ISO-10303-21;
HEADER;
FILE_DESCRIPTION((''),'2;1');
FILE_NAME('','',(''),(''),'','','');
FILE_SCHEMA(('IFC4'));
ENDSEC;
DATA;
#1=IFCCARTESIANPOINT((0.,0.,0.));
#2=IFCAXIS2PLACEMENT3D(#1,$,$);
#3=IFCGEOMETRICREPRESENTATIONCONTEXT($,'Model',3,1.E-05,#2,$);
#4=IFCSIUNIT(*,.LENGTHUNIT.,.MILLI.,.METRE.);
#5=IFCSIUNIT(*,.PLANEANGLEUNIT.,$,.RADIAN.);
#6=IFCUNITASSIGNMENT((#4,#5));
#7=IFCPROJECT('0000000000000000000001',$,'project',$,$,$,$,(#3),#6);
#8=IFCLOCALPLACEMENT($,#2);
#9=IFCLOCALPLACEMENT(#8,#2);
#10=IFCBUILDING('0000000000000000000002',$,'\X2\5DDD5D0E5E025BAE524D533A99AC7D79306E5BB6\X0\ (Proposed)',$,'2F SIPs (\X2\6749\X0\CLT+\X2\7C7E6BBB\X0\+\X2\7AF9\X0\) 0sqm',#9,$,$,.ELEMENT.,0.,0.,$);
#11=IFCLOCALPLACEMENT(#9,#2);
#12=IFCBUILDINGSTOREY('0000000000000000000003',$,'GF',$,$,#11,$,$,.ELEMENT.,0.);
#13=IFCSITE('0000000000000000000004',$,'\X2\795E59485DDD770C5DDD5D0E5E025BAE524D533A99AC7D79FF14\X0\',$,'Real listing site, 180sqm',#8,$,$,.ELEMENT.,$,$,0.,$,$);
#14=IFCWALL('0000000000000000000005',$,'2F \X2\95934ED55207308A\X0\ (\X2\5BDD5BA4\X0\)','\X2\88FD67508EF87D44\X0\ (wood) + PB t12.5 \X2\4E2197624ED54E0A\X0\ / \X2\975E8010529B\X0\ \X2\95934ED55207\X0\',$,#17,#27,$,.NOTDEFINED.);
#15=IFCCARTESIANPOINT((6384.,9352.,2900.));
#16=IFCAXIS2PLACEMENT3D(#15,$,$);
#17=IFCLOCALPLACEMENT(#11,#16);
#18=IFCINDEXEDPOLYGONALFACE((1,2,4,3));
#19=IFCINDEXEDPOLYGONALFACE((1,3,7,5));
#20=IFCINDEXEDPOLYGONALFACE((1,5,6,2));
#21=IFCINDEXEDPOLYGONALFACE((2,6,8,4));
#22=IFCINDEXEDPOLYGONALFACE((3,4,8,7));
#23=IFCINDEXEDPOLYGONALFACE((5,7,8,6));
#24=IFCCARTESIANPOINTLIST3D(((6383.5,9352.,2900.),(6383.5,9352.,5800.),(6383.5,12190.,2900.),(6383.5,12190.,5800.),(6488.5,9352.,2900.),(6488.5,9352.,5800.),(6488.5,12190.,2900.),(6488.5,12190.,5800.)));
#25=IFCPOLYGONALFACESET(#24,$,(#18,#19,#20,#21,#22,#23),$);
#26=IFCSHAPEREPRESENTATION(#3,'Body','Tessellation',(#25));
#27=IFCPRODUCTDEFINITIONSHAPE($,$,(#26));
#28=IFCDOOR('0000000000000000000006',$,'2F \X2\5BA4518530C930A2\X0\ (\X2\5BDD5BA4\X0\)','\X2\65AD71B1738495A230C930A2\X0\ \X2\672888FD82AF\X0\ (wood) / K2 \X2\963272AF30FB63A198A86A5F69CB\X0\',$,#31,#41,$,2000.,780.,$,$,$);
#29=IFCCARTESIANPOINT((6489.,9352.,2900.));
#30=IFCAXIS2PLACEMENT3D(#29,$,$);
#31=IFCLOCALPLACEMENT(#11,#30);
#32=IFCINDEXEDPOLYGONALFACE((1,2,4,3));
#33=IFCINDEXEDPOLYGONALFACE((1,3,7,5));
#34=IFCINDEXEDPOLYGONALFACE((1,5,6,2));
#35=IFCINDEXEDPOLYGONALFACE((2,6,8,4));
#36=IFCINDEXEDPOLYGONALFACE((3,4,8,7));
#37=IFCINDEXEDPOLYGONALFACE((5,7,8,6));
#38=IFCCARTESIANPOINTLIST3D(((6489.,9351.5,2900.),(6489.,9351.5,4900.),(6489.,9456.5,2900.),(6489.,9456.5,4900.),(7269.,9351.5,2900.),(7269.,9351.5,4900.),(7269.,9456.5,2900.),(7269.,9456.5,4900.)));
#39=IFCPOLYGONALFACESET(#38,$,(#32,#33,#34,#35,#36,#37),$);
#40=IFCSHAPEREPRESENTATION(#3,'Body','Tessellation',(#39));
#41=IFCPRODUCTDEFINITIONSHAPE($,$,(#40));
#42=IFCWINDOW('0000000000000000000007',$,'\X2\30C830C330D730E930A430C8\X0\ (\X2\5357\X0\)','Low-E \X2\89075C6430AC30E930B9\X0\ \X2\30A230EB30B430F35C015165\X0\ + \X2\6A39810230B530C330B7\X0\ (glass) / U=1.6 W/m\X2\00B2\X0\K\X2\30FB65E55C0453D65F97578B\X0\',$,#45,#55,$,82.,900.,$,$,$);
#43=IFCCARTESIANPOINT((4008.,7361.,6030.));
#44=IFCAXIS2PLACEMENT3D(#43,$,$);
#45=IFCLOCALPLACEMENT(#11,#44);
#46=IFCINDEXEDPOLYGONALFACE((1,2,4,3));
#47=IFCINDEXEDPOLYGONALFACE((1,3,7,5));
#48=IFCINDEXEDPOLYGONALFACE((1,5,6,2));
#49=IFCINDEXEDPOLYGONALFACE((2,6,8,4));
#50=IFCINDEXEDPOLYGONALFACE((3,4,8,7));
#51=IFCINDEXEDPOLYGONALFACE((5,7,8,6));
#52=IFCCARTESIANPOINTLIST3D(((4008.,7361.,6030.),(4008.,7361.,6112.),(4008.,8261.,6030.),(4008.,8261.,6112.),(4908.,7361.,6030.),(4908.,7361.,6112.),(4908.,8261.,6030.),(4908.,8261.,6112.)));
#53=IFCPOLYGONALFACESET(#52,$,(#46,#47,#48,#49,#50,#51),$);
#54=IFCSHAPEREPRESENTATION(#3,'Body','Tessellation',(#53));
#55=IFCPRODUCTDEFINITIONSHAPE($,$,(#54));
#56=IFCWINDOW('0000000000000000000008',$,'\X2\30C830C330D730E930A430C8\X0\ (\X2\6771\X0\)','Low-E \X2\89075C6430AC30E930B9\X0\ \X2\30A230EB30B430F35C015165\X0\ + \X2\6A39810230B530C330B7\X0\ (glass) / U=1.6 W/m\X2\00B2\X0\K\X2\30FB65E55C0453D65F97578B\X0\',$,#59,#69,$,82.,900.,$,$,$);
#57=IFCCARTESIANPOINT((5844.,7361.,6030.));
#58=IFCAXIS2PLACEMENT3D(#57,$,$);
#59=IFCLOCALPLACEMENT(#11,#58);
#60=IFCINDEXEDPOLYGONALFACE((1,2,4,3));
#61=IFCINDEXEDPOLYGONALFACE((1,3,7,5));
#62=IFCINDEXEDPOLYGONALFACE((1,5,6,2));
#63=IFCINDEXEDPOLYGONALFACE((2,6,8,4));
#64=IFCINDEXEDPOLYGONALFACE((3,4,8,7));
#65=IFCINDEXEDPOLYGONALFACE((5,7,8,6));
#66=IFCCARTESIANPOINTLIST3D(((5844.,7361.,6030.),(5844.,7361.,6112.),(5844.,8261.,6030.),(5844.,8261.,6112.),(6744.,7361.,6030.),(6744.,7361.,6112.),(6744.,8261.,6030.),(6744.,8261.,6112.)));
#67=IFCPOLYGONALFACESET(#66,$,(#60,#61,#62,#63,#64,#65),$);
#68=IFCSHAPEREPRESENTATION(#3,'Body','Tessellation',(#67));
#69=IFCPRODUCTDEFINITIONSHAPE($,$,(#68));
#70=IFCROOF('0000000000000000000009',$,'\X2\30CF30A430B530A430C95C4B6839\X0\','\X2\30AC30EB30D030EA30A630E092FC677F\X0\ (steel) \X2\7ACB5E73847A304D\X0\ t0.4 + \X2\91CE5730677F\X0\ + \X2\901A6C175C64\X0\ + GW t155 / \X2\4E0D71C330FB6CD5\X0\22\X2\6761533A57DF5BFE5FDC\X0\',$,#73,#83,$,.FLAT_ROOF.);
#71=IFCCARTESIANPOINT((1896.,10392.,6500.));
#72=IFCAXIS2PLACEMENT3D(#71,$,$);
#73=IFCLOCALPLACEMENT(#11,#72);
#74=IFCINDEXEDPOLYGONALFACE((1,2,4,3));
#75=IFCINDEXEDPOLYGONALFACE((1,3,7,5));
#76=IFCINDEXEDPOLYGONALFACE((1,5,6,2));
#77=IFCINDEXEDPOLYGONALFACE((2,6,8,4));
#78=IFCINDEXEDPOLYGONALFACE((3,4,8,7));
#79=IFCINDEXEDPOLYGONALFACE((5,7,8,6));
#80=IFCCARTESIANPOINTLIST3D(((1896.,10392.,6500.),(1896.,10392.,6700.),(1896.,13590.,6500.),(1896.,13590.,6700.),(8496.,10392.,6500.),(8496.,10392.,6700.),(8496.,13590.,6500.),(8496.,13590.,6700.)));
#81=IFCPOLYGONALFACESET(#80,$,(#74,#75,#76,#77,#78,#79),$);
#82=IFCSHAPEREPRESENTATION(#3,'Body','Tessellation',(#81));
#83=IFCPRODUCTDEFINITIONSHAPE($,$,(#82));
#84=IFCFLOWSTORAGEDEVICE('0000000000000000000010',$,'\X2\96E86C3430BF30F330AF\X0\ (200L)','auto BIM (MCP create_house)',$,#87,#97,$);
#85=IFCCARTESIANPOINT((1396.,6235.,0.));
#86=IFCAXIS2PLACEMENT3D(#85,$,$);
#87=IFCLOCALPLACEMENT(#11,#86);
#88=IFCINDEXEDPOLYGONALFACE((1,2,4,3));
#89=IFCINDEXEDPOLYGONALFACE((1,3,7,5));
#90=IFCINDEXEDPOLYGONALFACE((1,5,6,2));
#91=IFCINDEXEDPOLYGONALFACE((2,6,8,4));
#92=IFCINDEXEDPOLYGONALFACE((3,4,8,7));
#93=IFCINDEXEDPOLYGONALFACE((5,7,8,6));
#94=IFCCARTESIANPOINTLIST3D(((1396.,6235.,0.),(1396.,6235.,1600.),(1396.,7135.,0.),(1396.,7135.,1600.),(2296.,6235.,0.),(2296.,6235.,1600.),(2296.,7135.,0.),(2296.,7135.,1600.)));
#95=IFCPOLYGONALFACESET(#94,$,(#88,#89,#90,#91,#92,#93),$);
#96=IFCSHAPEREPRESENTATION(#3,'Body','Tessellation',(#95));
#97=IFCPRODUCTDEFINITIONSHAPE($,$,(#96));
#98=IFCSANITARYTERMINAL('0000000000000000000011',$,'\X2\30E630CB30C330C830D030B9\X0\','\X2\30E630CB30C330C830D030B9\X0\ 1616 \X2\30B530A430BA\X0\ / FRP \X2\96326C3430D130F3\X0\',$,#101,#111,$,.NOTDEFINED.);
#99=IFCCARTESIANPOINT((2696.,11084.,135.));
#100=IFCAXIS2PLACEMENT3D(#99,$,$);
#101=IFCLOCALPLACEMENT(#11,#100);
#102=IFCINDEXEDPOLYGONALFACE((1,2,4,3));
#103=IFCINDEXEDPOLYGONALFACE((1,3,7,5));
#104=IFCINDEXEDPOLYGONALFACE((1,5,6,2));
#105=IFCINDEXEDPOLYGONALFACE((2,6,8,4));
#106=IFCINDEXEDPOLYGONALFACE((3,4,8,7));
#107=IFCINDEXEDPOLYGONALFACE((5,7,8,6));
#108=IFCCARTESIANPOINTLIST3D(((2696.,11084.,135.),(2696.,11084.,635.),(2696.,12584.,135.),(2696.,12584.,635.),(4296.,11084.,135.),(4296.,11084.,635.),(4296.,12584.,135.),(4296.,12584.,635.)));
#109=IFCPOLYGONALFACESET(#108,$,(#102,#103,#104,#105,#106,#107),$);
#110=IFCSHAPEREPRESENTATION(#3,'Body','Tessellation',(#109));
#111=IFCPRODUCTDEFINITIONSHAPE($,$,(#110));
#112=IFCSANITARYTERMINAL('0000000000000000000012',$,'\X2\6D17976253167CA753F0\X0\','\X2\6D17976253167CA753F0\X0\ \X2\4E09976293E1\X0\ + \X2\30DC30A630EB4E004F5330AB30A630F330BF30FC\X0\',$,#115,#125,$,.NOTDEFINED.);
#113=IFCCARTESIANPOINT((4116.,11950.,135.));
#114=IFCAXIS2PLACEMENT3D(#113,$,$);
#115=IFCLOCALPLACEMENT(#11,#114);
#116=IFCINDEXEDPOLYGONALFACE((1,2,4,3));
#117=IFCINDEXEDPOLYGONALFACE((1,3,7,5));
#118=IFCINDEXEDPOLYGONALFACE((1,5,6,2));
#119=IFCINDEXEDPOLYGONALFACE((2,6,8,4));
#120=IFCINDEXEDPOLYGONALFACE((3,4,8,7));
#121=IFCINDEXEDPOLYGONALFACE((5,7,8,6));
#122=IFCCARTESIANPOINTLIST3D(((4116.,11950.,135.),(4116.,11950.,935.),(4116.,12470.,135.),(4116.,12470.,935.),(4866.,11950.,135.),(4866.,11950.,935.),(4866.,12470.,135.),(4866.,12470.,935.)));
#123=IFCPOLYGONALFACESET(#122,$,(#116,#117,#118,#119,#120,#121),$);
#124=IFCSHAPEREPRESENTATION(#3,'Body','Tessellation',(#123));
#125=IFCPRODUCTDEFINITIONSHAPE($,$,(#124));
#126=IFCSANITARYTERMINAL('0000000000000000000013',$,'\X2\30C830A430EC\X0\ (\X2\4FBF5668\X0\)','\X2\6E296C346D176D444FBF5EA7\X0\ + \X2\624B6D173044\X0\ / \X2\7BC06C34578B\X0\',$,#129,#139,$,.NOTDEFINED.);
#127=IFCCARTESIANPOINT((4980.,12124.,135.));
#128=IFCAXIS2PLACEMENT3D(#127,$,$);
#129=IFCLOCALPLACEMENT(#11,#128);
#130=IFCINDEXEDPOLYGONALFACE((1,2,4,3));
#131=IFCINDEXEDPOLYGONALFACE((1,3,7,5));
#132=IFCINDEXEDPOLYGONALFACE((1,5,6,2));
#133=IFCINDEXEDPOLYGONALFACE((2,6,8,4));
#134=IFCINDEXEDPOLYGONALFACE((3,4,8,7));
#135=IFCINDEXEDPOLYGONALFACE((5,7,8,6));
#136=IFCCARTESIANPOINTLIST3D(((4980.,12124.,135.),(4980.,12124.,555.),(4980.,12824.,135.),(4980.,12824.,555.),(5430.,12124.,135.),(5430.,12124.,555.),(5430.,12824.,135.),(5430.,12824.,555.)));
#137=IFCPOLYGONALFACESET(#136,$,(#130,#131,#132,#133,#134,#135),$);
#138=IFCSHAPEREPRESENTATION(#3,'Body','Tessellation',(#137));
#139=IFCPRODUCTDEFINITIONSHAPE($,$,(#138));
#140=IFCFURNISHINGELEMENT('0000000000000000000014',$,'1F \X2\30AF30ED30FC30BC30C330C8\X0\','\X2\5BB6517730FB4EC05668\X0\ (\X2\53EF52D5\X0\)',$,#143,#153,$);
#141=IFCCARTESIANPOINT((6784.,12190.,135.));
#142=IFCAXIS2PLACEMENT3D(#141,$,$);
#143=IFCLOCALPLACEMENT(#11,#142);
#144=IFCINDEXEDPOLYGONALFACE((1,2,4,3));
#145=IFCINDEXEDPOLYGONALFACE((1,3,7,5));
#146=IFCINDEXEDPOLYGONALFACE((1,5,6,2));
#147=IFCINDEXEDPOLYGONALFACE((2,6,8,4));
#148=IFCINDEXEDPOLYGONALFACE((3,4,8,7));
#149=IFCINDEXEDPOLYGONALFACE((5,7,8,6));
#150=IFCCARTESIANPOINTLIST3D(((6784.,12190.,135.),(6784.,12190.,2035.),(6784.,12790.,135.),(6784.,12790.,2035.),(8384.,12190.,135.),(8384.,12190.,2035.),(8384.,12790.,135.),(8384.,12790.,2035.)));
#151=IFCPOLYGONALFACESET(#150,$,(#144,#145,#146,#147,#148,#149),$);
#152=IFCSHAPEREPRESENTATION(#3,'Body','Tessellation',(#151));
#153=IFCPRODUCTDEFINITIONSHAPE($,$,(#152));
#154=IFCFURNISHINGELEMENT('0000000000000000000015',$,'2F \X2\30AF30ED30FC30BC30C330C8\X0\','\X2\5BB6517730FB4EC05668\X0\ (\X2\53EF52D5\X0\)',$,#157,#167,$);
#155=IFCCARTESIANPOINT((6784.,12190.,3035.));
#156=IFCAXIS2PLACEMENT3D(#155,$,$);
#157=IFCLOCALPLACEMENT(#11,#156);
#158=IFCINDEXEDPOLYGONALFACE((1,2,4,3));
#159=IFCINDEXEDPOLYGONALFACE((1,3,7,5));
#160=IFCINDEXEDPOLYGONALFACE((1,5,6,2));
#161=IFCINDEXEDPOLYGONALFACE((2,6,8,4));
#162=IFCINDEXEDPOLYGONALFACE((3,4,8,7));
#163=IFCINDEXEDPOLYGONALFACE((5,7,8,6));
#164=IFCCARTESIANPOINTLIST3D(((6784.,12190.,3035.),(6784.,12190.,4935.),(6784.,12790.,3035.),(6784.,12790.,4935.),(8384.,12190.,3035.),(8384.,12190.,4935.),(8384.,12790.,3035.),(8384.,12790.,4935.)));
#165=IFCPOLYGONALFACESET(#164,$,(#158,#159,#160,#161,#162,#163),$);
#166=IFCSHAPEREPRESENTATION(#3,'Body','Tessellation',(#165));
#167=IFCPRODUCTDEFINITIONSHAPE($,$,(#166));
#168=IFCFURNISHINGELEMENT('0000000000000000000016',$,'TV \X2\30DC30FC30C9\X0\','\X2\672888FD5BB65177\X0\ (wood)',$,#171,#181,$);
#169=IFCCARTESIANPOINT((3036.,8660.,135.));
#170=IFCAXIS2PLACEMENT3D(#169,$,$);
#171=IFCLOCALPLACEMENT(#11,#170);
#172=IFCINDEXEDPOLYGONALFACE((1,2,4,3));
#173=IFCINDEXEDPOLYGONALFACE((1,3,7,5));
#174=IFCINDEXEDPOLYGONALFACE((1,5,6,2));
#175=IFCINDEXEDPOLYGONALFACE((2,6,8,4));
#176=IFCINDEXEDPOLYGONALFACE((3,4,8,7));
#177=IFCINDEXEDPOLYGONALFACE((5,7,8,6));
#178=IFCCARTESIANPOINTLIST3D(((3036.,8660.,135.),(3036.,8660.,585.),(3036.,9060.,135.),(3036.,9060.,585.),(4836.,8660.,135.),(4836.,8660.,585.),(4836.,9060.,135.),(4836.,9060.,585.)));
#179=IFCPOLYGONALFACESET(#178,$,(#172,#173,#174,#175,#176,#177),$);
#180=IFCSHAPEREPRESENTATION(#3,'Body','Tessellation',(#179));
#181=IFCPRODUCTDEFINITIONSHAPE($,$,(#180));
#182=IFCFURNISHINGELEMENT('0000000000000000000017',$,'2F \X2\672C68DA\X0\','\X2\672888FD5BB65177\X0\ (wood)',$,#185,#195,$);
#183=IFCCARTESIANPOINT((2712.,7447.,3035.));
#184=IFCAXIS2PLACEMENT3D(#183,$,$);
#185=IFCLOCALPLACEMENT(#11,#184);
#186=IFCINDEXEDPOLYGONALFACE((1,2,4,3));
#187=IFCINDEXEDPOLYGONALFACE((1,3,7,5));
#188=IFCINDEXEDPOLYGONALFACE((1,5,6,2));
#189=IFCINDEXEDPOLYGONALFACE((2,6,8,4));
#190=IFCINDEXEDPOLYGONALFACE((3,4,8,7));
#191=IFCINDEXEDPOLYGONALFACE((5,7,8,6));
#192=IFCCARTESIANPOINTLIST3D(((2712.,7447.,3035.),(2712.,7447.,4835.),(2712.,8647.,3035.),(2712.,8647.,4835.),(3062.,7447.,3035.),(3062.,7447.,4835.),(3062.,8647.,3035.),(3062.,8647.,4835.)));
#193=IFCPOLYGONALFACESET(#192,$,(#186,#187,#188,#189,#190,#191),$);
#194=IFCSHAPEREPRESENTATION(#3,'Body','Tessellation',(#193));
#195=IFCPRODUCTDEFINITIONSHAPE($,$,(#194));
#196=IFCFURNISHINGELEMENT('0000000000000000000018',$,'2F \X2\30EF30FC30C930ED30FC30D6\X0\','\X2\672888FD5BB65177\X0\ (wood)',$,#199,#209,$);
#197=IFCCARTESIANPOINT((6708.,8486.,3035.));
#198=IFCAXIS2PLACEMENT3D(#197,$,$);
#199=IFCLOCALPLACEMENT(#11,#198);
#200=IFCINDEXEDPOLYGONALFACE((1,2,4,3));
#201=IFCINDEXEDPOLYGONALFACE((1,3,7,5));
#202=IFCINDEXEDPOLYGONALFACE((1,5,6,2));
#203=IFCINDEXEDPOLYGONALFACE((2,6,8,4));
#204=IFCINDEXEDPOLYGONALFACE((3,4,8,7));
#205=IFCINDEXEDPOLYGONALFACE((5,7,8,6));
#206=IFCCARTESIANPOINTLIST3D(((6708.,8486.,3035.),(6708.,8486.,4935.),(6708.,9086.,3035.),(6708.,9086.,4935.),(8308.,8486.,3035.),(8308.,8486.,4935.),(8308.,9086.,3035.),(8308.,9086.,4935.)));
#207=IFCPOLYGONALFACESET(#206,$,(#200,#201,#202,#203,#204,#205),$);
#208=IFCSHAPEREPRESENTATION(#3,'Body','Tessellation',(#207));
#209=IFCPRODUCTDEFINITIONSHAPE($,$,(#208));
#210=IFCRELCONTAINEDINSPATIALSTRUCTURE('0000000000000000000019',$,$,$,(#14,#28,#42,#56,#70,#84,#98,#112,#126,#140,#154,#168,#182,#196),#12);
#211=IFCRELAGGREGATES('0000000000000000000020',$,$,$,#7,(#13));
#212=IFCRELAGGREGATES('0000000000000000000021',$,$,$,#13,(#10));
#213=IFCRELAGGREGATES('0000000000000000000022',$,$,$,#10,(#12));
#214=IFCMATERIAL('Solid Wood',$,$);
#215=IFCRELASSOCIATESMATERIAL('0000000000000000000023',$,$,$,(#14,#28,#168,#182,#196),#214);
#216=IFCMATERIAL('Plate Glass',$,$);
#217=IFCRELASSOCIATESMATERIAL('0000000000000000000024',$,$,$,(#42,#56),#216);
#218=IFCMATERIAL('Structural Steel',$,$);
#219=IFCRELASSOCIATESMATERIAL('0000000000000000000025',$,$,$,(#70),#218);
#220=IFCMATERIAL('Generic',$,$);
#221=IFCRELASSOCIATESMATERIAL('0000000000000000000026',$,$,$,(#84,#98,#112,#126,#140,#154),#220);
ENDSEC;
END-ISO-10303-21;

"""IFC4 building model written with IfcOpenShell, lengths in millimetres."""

from ifc_helpers import new_model, si_unit, frame, frame_2d, origin, place, context, project, spatial, rectangle, extrude, material, element, save


model = new_model("IFC4")

# Units and contexts
model_context = context("Model", 3, precision=1e-05, world=origin())
ifc_project = project(units=[si_unit("LENGTHUNIT", "METRE", prefix="MILLI"), si_unit("PLANEANGLEUNIT", "RADIAN")], contexts=[model_context])

# Site, building, storey
site_placement = place(None, origin())
site = spatial("IfcSite", under=ifc_project, at=site_placement, Name="神奈川県川崎市宮前区馬絹４", ObjectType="Real listing site, 180sqm", CompositionType="ELEMENT", RefElevation=0.0)
building_placement = place(site_placement, origin())
building = spatial("IfcBuilding", under=site, at=building_placement, Name="川崎市宮前区馬絹の家 (Proposed)", ObjectType="2F SIPs (杉CLT+籾殻+竹) 0sqm", CompositionType="ELEMENT", ElevationOfRefHeight=0.0, ElevationOfTerrain=0.0)
storey_placement = place(building_placement, origin())
storey = spatial("IfcBuildingStorey", under=building, at=storey_placement, Name="GF", CompositionType="ELEMENT", Elevation=0.0)

# Shared definitions
ifc_material_1 = material(Name="Solid Wood")
ifc_material_2 = material(Name="Plate Glass")

# Wall
wall_1_placement = place(storey_placement, frame((6384.0, 9352.0, 2900.0)))
element("IfcWall", 1, at=wall_1_placement, inside=storey, material=ifc_material_1, Name="2F 間仕切り (寝室)", Description="製材軸組 (wood) + PB t12.5 両面仕上 / 非耐力 間仕切", PredefinedType="NOTDEFINED", context=model_context, shape_type="SweptSolid", body=[
    extrude(rectangle(XDim=105.0, YDim=2838.0, at=frame_2d((52.0, 1419.0))), frame((6384.0, 9352.0, 2900.0)), (0.0, 0.0, 1.0), 2900.0),
])

# Door
door_1_placement = place(storey_placement, frame((6489.0, 9352.0, 2900.0)))
element("IfcDoor", 2, at=door_1_placement, inside=storey, material=ifc_material_1, Name="2F 室内ドア (寝室)", Description="断熱玄関ドア 木製芯 (wood) / K2 防犯・採風機構", OverallHeight=2000.0, OverallWidth=780.0, context=model_context, shape_type="SweptSolid", body=[
    extrude(rectangle(XDim=780.0, YDim=105.0, at=frame_2d((390.0, 52.0))), frame((6489.0, 9352.0, 2900.0)), (0.0, 0.0, 1.0), 2000.0),
])

# Windows
window_1_placement = place(storey_placement, frame((4008.0, 7361.0, 6030.0)))
element("IfcWindow", 3, at=window_1_placement, inside=storey, material=ifc_material_2, Name="トップライト (南)", Description="Low-E 複層ガラス アルゴン封入 + 樹脂サッシ (glass) / U=1.6 W/m²K・日射取得型", OverallHeight=82.0, OverallWidth=900.0, context=model_context, shape_type="SweptSolid", body=[
    extrude(rectangle(XDim=900.0, YDim=900.0, at=frame_2d((450.0, 450.0))), frame((4008.0, 7361.0, 6030.0)), (0.0, 0.0, 1.0), 82.0),
])
window_2_placement = place(storey_placement, frame((5844.0, 7361.0, 6030.0)))
element("IfcWindow", 4, at=window_2_placement, inside=storey, material=ifc_material_2, Name="トップライト (東)", Description="Low-E 複層ガラス アルゴン封入 + 樹脂サッシ (glass) / U=1.6 W/m²K・日射取得型", OverallHeight=82.0, OverallWidth=900.0, context=model_context, shape_type="SweptSolid", body=[
    extrude(rectangle(XDim=900.0, YDim=900.0, at=frame_2d((450.0, 450.0))), frame((5844.0, 7361.0, 6030.0)), (0.0, 0.0, 1.0), 82.0),
])

# Roof
ifc_material_3 = material(Name="Structural Steel")
roof_placement = place(storey_placement, frame((1896.0, 10392.0, 6500.0)))
element("IfcRoof", 5, at=roof_placement, inside=storey, material=ifc_material_3, Name="ハイサイド屋根", Description="ガルバリウム鋼板 (steel) 立平葺き t0.4 + 野地板 + 通気層 + GW t155 / 不燃・法22条区域対応", PredefinedType="FLAT_ROOF", context=model_context, shape_type="SweptSolid", body=[
    extrude(rectangle(XDim=6600.0, YDim=3198.0, at=frame_2d((3300.0, 1599.0))), frame((1896.0, 10392.0, 6500.0)), (0.0, 0.0, 1.0), 200.0),
])

# Flow storage device
ifc_material_4 = material(Name="Generic")
flow_storage_device_placement = place(storey_placement, frame((1396.0, 6235.0, 0.0)))
element("IfcFlowStorageDevice", 6, at=flow_storage_device_placement, inside=storey, material=ifc_material_4, Name="雨水タンク (200L)", Description="auto BIM (MCP create_house)", context=model_context, shape_type="SweptSolid", body=[
    extrude(rectangle(XDim=900.0, YDim=900.0, at=frame_2d((450.0, 450.0))), frame((1396.0, 6235.0, 0.0)), (0.0, 0.0, 1.0), 1600.0),
])

# Sanitary terminals
sanitary_terminal_1_placement = place(storey_placement, frame((2696.0, 11084.0, 135.0)))
element("IfcSanitaryTerminal", 7, at=sanitary_terminal_1_placement, inside=storey, material=ifc_material_4, Name="ユニットバス", Description="ユニットバス 1616 サイズ / FRP 防水パン", PredefinedType="NOTDEFINED", context=model_context, shape_type="SweptSolid", body=[
    extrude(rectangle(XDim=1600.0, YDim=1500.0, at=frame_2d((800.0, 750.0))), frame((2696.0, 11084.0, 135.0)), (0.0, 0.0, 1.0), 500.0),
])
sanitary_terminal_2_placement = place(storey_placement, frame((4116.0, 11950.0, 135.0)))
element("IfcSanitaryTerminal", 8, at=sanitary_terminal_2_placement, inside=storey, material=ifc_material_4, Name="洗面化粧台", Description="洗面化粧台 三面鏡 + ボウル一体カウンター", PredefinedType="NOTDEFINED", context=model_context, shape_type="SweptSolid", body=[
    extrude(rectangle(XDim=750.0, YDim=520.0, at=frame_2d((375.0, 260.0))), frame((4116.0, 11950.0, 135.0)), (0.0, 0.0, 1.0), 800.0),
])
sanitary_terminal_3_placement = place(storey_placement, frame((4980.0, 12124.0, 135.0)))
element("IfcSanitaryTerminal", 9, at=sanitary_terminal_3_placement, inside=storey, material=ifc_material_4, Name="トイレ (便器)", Description="温水洗浄便座 + 手洗い / 節水型", PredefinedType="NOTDEFINED", context=model_context, shape_type="SweptSolid", body=[
    extrude(rectangle(XDim=450.0, YDim=700.0, at=frame_2d((225.0, 350.0))), frame((4980.0, 12124.0, 135.0)), (0.0, 0.0, 1.0), 420.0),
])

# Furnishing elements
furnishing_1_placement = place(storey_placement, frame((6784.0, 12190.0, 135.0)))
element("IfcFurnishingElement", 10, at=furnishing_1_placement, inside=storey, material=ifc_material_4, Name="1F クローゼット", Description="家具・什器 (可動)", context=model_context, shape_type="SweptSolid", body=[
    extrude(rectangle(XDim=1600.0, YDim=600.0, at=frame_2d((800.0, 300.0))), frame((6784.0, 12190.0, 135.0)), (0.0, 0.0, 1.0), 1900.0),
])
furnishing_2_placement = place(storey_placement, frame((6784.0, 12190.0, 3035.0)))
element("IfcFurnishingElement", 11, at=furnishing_2_placement, inside=storey, material=ifc_material_4, Name="2F クローゼット", Description="家具・什器 (可動)", context=model_context, shape_type="SweptSolid", body=[
    extrude(rectangle(XDim=1600.0, YDim=600.0, at=frame_2d((800.0, 300.0))), frame((6784.0, 12190.0, 3035.0)), (0.0, 0.0, 1.0), 1900.0),
])
furnishing_3_placement = place(storey_placement, frame((3036.0, 8660.0, 135.0)))
element("IfcFurnishingElement", 12, at=furnishing_3_placement, inside=storey, material=ifc_material_1, Name="TV ボード", Description="木製家具 (wood)", context=model_context, shape_type="SweptSolid", body=[
    extrude(rectangle(XDim=1800.0, YDim=400.0, at=frame_2d((900.0, 200.0))), frame((3036.0, 8660.0, 135.0)), (0.0, 0.0, 1.0), 450.0),
])
furnishing_4_placement = place(storey_placement, frame((2712.0, 7447.0, 3035.0)))
element("IfcFurnishingElement", 13, at=furnishing_4_placement, inside=storey, material=ifc_material_1, Name="2F 本棚", Description="木製家具 (wood)", context=model_context, shape_type="SweptSolid", body=[
    extrude(rectangle(XDim=350.0, YDim=1200.0, at=frame_2d((175.0, 600.0))), frame((2712.0, 7447.0, 3035.0)), (0.0, 0.0, 1.0), 1800.0),
])
furnishing_5_placement = place(storey_placement, frame((6708.0, 8486.0, 3035.0)))
element("IfcFurnishingElement", 14, at=furnishing_5_placement, inside=storey, material=ifc_material_1, Name="2F ワードローブ", Description="木製家具 (wood)", context=model_context, shape_type="SweptSolid", body=[
    extrude(rectangle(XDim=1600.0, YDim=600.0, at=frame_2d((800.0, 300.0))), frame((6708.0, 8486.0, 3035.0)), (0.0, 0.0, 1.0), 1900.0),
])

save(model, "model.ifc")
